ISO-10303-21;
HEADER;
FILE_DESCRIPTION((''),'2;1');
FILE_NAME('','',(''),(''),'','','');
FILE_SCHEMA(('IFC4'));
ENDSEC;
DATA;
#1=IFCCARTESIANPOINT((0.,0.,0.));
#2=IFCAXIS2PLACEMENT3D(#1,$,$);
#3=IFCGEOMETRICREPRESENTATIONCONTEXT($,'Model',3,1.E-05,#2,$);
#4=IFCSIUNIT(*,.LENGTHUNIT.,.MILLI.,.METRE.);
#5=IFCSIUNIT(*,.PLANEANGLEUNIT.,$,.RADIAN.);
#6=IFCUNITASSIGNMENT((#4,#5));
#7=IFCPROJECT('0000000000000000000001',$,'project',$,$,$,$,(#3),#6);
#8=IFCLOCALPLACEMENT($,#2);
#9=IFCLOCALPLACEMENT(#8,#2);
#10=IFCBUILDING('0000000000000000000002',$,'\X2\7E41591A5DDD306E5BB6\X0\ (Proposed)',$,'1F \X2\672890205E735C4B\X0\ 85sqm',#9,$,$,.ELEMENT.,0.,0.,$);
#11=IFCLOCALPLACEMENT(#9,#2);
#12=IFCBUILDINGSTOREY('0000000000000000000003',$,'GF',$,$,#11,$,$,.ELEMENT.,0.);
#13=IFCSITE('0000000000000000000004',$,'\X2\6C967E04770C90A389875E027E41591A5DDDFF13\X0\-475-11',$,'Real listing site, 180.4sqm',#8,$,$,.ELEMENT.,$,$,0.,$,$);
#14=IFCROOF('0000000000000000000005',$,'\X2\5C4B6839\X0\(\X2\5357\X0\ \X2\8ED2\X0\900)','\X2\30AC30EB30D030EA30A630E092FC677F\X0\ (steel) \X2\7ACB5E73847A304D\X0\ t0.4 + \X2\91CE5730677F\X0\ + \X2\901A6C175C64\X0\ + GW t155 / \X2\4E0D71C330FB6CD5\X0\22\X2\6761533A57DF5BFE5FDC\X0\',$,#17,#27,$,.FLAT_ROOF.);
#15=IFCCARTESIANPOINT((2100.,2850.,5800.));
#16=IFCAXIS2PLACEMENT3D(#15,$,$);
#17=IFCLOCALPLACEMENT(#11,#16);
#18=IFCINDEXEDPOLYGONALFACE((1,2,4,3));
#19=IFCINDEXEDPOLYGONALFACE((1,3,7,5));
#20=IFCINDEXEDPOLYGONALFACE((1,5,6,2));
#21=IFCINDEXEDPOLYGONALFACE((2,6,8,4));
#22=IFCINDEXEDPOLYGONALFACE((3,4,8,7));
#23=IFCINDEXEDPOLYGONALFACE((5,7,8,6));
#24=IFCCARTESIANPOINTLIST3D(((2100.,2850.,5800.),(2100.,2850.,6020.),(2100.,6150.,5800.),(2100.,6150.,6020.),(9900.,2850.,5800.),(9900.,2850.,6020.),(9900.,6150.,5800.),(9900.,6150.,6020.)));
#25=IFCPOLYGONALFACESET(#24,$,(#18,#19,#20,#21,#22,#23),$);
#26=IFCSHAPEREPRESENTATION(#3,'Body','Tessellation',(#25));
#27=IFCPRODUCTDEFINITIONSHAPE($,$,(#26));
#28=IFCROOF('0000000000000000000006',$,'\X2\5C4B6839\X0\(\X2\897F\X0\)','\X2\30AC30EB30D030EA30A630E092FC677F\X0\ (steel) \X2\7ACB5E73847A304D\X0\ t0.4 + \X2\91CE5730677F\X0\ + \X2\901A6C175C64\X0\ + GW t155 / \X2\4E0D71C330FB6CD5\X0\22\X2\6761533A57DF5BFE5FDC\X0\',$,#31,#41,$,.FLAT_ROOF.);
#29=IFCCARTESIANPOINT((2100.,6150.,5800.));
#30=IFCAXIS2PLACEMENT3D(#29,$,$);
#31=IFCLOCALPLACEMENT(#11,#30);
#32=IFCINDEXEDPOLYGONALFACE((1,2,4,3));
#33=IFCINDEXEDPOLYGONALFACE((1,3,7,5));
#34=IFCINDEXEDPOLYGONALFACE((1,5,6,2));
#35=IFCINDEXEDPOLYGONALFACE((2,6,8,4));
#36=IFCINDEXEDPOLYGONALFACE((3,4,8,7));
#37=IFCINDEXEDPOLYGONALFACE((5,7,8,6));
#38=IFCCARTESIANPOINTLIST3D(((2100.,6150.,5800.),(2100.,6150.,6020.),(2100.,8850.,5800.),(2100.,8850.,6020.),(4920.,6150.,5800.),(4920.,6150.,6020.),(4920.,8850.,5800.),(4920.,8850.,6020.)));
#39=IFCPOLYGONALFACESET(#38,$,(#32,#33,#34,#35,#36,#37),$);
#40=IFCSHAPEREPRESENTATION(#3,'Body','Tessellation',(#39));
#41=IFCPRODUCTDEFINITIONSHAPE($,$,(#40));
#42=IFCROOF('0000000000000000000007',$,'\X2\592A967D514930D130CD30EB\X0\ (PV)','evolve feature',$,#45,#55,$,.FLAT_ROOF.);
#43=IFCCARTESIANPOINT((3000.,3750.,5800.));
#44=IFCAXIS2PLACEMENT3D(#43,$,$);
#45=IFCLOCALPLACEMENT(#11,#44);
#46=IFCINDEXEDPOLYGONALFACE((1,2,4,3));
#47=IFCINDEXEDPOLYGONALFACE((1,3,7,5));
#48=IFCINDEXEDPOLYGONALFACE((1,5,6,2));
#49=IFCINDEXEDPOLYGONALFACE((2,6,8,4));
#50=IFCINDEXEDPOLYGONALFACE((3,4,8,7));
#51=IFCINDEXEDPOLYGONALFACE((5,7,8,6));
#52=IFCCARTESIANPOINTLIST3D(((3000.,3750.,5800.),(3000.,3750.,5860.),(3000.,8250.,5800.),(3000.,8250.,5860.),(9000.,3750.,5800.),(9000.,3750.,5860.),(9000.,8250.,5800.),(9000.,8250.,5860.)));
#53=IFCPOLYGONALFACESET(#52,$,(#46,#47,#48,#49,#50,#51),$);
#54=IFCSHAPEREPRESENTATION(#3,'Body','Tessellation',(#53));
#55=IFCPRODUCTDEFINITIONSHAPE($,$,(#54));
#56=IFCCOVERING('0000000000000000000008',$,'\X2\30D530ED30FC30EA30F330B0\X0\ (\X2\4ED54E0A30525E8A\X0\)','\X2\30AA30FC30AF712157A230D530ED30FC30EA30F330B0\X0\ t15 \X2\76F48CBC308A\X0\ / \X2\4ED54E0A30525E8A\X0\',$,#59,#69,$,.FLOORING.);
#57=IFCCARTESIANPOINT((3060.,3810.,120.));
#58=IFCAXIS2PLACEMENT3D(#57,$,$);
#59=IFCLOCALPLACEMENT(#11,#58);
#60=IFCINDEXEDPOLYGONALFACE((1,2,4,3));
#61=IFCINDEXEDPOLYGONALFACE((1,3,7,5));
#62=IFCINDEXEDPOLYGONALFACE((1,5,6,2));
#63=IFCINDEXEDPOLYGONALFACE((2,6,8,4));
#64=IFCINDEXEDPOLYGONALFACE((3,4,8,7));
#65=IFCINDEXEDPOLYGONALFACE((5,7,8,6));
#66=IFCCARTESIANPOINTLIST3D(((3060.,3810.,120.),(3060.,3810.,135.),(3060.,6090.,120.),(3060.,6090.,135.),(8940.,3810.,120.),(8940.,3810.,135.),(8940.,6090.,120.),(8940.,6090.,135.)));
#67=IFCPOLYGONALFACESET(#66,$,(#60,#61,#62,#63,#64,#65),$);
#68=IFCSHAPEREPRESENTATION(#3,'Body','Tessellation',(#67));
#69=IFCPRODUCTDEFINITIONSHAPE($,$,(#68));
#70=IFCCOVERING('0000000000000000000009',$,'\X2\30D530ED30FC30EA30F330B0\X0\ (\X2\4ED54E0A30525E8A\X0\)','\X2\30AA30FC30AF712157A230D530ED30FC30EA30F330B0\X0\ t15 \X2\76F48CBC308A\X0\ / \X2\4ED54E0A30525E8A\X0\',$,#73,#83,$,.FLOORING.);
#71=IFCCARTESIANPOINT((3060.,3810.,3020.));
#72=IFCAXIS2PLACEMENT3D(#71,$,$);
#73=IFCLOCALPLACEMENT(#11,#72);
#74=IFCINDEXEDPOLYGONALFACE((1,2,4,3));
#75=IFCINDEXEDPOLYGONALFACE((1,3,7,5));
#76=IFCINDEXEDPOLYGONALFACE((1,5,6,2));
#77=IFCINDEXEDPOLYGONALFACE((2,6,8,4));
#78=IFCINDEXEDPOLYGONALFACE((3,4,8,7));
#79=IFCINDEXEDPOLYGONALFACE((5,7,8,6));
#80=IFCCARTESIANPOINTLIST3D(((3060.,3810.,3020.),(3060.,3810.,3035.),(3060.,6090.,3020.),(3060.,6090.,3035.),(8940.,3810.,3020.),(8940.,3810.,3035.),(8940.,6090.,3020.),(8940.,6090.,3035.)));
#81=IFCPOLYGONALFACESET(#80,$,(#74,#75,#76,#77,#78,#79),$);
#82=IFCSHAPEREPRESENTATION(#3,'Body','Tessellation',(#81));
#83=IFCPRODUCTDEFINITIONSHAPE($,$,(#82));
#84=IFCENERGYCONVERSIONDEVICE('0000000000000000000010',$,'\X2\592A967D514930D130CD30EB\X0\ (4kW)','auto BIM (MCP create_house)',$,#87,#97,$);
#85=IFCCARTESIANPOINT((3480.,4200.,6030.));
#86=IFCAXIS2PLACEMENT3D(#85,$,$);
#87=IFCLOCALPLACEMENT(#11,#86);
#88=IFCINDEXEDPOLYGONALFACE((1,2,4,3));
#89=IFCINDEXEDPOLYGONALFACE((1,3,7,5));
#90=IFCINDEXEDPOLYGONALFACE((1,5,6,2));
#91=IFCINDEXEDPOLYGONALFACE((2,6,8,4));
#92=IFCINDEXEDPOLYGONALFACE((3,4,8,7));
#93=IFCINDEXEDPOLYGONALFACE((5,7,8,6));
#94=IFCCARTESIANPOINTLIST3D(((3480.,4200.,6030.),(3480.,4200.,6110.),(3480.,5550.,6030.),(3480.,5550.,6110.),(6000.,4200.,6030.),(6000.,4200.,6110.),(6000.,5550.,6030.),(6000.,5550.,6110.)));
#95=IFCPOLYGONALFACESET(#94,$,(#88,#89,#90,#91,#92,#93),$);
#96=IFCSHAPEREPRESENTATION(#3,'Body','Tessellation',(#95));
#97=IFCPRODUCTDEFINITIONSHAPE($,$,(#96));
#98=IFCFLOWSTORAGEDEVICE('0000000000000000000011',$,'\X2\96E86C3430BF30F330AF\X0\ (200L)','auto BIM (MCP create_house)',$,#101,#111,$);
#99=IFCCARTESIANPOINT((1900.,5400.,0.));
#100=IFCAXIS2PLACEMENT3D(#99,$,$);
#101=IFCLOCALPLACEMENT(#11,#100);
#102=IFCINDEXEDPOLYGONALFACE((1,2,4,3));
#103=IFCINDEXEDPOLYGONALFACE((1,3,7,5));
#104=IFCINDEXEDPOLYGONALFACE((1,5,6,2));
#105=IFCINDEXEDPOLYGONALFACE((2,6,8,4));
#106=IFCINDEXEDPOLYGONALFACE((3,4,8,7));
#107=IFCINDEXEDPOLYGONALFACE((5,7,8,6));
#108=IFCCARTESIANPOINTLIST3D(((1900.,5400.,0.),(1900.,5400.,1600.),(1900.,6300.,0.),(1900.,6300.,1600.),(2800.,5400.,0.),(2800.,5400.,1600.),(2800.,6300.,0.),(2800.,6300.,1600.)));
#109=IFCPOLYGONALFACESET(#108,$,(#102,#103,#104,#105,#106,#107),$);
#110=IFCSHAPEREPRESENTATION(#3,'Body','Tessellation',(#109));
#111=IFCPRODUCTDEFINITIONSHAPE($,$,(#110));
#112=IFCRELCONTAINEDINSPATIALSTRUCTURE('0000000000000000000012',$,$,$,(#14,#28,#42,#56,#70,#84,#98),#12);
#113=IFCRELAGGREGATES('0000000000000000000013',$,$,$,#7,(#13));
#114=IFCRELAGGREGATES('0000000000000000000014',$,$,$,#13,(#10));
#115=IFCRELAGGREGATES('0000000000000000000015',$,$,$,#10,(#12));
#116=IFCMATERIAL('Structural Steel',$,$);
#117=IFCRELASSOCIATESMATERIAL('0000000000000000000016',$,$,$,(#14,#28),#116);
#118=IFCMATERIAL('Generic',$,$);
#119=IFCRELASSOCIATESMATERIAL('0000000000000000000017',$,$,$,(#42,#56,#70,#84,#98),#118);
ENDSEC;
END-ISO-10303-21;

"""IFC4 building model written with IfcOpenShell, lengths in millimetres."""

from ifc_helpers import new_model, si_unit, frame, frame_2d, origin, place, context, project, spatial, rectangle, extrude, material, element, save


model = new_model("IFC4")

# Units and contexts
model_context = context("Model", 3, precision=1e-05, world=origin())
ifc_project = project(units=[si_unit("LENGTHUNIT", "METRE", prefix="MILLI"), si_unit("PLANEANGLEUNIT", "RADIAN")], contexts=[model_context])

# Site, building, storey
site_placement = place(None, origin())
site = spatial("IfcSite", under=ifc_project, at=site_placement, Name="沖縄県那覇市繁多川３-475-11", ObjectType="Real listing site, 180.4sqm", CompositionType="ELEMENT", RefElevation=0.0)
building_placement = place(site_placement, origin())
building = spatial("IfcBuilding", under=site, at=building_placement, Name="繁多川の家 (Proposed)", ObjectType="1F 木造平屋 85sqm", CompositionType="ELEMENT", ElevationOfRefHeight=0.0, ElevationOfTerrain=0.0)
storey_placement = place(building_placement, origin())
storey = spatial("IfcBuildingStorey", under=building, at=storey_placement, Name="GF", CompositionType="ELEMENT", Elevation=0.0)

# Shared definitions
ifc_material_1 = material(Name="Generic")

# Roofs
ifc_material_2 = material(Name="Structural Steel")
roof_1_placement = place(storey_placement, frame((2100.0, 2850.0, 5800.0)))
element("IfcRoof", 1, at=roof_1_placement, inside=storey, material=ifc_material_2, Name="屋根(南 軒900)", Description="ガルバリウム鋼板 (steel) 立平葺き t0.4 + 野地板 + 通気層 + GW t155 / 不燃・法22条区域対応", PredefinedType="FLAT_ROOF", context=model_context, shape_type="SweptSolid", body=[
    extrude(rectangle(XDim=7800.0, YDim=3300.0, at=frame_2d((3900.0, 1650.0))), frame((2100.0, 2850.0, 5800.0)), (0.0, 0.0, 1.0), 220.0),
])
roof_2_placement = place(storey_placement, frame((2100.0, 6150.0, 5800.0)))
element("IfcRoof", 2, at=roof_2_placement, inside=storey, material=ifc_material_2, Name="屋根(西)", Description="ガルバリウム鋼板 (steel) 立平葺き t0.4 + 野地板 + 通気層 + GW t155 / 不燃・法22条区域対応", PredefinedType="FLAT_ROOF", context=model_context, shape_type="SweptSolid", body=[
    extrude(rectangle(XDim=2820.0, YDim=2700.0, at=frame_2d((1410.0, 1350.0))), frame((2100.0, 6150.0, 5800.0)), (0.0, 0.0, 1.0), 220.0),
])
roof_3_placement = place(storey_placement, frame((3000.0, 3750.0, 5800.0)))
element("IfcRoof", 3, at=roof_3_placement, inside=storey, material=ifc_material_1, Name="太陽光パネル (PV)", Description="evolve feature", PredefinedType="FLAT_ROOF", context=model_context, shape_type="SweptSolid", body=[
    extrude(rectangle(XDim=6000.0, YDim=4500.0, at=frame_2d((3000.0, 2250.0))), frame((3000.0, 3750.0, 5800.0)), (0.0, 0.0, 1.0), 60.0),
])

# Coverings
covering_1_placement = place(storey_placement, frame((3060.0, 3810.0, 120.0)))
element("IfcCovering", 4, at=covering_1_placement, inside=storey, material=ifc_material_1, Name="フローリング (仕上げ床)", Description="オーク無垢フローリング t15 直貼り / 仕上げ床", PredefinedType="FLOORING", context=model_context, shape_type="SweptSolid", body=[
    extrude(rectangle(XDim=5880.0, YDim=2280.0, at=frame_2d((2940.0, 1140.0))), frame((3060.0, 3810.0, 120.0)), (0.0, 0.0, 1.0), 15.0),
])
covering_2_placement = place(storey_placement, frame((3060.0, 3810.0, 3020.0)))
element("IfcCovering", 5, at=covering_2_placement, inside=storey, material=ifc_material_1, Name="フローリング (仕上げ床)", Description="オーク無垢フローリング t15 直貼り / 仕上げ床", PredefinedType="FLOORING", context=model_context, shape_type="SweptSolid", body=[
    extrude(rectangle(XDim=5880.0, YDim=2280.0, at=frame_2d((2940.0, 1140.0))), frame((3060.0, 3810.0, 3020.0)), (0.0, 0.0, 1.0), 15.0),
])

# Energy conversion device
energy_conversion_device_placement = place(storey_placement, frame((3480.0, 4200.0, 6030.0)))
element("IfcEnergyConversionDevice", 6, at=energy_conversion_device_placement, inside=storey, material=ifc_material_1, Name="太陽光パネル (4kW)", Description="auto BIM (MCP create_house)", context=model_context, shape_type="SweptSolid", body=[
    extrude(rectangle(XDim=2520.0, YDim=1350.0, at=frame_2d((1260.0, 675.0))), frame((3480.0, 4200.0, 6030.0)), (0.0, 0.0, 1.0), 80.0),
])

# Flow storage device
flow_storage_device_placement = place(storey_placement, frame((1900.0, 5400.0, 0.0)))
element("IfcFlowStorageDevice", 7, at=flow_storage_device_placement, inside=storey, material=ifc_material_1, Name="雨水タンク (200L)", Description="auto BIM (MCP create_house)", context=model_context, shape_type="SweptSolid", body=[
    extrude(rectangle(XDim=900.0, YDim=900.0, at=frame_2d((450.0, 450.0))), frame((1900.0, 5400.0, 0.0)), (0.0, 0.0, 1.0), 1600.0),
])

save(model, "model.ifc")
